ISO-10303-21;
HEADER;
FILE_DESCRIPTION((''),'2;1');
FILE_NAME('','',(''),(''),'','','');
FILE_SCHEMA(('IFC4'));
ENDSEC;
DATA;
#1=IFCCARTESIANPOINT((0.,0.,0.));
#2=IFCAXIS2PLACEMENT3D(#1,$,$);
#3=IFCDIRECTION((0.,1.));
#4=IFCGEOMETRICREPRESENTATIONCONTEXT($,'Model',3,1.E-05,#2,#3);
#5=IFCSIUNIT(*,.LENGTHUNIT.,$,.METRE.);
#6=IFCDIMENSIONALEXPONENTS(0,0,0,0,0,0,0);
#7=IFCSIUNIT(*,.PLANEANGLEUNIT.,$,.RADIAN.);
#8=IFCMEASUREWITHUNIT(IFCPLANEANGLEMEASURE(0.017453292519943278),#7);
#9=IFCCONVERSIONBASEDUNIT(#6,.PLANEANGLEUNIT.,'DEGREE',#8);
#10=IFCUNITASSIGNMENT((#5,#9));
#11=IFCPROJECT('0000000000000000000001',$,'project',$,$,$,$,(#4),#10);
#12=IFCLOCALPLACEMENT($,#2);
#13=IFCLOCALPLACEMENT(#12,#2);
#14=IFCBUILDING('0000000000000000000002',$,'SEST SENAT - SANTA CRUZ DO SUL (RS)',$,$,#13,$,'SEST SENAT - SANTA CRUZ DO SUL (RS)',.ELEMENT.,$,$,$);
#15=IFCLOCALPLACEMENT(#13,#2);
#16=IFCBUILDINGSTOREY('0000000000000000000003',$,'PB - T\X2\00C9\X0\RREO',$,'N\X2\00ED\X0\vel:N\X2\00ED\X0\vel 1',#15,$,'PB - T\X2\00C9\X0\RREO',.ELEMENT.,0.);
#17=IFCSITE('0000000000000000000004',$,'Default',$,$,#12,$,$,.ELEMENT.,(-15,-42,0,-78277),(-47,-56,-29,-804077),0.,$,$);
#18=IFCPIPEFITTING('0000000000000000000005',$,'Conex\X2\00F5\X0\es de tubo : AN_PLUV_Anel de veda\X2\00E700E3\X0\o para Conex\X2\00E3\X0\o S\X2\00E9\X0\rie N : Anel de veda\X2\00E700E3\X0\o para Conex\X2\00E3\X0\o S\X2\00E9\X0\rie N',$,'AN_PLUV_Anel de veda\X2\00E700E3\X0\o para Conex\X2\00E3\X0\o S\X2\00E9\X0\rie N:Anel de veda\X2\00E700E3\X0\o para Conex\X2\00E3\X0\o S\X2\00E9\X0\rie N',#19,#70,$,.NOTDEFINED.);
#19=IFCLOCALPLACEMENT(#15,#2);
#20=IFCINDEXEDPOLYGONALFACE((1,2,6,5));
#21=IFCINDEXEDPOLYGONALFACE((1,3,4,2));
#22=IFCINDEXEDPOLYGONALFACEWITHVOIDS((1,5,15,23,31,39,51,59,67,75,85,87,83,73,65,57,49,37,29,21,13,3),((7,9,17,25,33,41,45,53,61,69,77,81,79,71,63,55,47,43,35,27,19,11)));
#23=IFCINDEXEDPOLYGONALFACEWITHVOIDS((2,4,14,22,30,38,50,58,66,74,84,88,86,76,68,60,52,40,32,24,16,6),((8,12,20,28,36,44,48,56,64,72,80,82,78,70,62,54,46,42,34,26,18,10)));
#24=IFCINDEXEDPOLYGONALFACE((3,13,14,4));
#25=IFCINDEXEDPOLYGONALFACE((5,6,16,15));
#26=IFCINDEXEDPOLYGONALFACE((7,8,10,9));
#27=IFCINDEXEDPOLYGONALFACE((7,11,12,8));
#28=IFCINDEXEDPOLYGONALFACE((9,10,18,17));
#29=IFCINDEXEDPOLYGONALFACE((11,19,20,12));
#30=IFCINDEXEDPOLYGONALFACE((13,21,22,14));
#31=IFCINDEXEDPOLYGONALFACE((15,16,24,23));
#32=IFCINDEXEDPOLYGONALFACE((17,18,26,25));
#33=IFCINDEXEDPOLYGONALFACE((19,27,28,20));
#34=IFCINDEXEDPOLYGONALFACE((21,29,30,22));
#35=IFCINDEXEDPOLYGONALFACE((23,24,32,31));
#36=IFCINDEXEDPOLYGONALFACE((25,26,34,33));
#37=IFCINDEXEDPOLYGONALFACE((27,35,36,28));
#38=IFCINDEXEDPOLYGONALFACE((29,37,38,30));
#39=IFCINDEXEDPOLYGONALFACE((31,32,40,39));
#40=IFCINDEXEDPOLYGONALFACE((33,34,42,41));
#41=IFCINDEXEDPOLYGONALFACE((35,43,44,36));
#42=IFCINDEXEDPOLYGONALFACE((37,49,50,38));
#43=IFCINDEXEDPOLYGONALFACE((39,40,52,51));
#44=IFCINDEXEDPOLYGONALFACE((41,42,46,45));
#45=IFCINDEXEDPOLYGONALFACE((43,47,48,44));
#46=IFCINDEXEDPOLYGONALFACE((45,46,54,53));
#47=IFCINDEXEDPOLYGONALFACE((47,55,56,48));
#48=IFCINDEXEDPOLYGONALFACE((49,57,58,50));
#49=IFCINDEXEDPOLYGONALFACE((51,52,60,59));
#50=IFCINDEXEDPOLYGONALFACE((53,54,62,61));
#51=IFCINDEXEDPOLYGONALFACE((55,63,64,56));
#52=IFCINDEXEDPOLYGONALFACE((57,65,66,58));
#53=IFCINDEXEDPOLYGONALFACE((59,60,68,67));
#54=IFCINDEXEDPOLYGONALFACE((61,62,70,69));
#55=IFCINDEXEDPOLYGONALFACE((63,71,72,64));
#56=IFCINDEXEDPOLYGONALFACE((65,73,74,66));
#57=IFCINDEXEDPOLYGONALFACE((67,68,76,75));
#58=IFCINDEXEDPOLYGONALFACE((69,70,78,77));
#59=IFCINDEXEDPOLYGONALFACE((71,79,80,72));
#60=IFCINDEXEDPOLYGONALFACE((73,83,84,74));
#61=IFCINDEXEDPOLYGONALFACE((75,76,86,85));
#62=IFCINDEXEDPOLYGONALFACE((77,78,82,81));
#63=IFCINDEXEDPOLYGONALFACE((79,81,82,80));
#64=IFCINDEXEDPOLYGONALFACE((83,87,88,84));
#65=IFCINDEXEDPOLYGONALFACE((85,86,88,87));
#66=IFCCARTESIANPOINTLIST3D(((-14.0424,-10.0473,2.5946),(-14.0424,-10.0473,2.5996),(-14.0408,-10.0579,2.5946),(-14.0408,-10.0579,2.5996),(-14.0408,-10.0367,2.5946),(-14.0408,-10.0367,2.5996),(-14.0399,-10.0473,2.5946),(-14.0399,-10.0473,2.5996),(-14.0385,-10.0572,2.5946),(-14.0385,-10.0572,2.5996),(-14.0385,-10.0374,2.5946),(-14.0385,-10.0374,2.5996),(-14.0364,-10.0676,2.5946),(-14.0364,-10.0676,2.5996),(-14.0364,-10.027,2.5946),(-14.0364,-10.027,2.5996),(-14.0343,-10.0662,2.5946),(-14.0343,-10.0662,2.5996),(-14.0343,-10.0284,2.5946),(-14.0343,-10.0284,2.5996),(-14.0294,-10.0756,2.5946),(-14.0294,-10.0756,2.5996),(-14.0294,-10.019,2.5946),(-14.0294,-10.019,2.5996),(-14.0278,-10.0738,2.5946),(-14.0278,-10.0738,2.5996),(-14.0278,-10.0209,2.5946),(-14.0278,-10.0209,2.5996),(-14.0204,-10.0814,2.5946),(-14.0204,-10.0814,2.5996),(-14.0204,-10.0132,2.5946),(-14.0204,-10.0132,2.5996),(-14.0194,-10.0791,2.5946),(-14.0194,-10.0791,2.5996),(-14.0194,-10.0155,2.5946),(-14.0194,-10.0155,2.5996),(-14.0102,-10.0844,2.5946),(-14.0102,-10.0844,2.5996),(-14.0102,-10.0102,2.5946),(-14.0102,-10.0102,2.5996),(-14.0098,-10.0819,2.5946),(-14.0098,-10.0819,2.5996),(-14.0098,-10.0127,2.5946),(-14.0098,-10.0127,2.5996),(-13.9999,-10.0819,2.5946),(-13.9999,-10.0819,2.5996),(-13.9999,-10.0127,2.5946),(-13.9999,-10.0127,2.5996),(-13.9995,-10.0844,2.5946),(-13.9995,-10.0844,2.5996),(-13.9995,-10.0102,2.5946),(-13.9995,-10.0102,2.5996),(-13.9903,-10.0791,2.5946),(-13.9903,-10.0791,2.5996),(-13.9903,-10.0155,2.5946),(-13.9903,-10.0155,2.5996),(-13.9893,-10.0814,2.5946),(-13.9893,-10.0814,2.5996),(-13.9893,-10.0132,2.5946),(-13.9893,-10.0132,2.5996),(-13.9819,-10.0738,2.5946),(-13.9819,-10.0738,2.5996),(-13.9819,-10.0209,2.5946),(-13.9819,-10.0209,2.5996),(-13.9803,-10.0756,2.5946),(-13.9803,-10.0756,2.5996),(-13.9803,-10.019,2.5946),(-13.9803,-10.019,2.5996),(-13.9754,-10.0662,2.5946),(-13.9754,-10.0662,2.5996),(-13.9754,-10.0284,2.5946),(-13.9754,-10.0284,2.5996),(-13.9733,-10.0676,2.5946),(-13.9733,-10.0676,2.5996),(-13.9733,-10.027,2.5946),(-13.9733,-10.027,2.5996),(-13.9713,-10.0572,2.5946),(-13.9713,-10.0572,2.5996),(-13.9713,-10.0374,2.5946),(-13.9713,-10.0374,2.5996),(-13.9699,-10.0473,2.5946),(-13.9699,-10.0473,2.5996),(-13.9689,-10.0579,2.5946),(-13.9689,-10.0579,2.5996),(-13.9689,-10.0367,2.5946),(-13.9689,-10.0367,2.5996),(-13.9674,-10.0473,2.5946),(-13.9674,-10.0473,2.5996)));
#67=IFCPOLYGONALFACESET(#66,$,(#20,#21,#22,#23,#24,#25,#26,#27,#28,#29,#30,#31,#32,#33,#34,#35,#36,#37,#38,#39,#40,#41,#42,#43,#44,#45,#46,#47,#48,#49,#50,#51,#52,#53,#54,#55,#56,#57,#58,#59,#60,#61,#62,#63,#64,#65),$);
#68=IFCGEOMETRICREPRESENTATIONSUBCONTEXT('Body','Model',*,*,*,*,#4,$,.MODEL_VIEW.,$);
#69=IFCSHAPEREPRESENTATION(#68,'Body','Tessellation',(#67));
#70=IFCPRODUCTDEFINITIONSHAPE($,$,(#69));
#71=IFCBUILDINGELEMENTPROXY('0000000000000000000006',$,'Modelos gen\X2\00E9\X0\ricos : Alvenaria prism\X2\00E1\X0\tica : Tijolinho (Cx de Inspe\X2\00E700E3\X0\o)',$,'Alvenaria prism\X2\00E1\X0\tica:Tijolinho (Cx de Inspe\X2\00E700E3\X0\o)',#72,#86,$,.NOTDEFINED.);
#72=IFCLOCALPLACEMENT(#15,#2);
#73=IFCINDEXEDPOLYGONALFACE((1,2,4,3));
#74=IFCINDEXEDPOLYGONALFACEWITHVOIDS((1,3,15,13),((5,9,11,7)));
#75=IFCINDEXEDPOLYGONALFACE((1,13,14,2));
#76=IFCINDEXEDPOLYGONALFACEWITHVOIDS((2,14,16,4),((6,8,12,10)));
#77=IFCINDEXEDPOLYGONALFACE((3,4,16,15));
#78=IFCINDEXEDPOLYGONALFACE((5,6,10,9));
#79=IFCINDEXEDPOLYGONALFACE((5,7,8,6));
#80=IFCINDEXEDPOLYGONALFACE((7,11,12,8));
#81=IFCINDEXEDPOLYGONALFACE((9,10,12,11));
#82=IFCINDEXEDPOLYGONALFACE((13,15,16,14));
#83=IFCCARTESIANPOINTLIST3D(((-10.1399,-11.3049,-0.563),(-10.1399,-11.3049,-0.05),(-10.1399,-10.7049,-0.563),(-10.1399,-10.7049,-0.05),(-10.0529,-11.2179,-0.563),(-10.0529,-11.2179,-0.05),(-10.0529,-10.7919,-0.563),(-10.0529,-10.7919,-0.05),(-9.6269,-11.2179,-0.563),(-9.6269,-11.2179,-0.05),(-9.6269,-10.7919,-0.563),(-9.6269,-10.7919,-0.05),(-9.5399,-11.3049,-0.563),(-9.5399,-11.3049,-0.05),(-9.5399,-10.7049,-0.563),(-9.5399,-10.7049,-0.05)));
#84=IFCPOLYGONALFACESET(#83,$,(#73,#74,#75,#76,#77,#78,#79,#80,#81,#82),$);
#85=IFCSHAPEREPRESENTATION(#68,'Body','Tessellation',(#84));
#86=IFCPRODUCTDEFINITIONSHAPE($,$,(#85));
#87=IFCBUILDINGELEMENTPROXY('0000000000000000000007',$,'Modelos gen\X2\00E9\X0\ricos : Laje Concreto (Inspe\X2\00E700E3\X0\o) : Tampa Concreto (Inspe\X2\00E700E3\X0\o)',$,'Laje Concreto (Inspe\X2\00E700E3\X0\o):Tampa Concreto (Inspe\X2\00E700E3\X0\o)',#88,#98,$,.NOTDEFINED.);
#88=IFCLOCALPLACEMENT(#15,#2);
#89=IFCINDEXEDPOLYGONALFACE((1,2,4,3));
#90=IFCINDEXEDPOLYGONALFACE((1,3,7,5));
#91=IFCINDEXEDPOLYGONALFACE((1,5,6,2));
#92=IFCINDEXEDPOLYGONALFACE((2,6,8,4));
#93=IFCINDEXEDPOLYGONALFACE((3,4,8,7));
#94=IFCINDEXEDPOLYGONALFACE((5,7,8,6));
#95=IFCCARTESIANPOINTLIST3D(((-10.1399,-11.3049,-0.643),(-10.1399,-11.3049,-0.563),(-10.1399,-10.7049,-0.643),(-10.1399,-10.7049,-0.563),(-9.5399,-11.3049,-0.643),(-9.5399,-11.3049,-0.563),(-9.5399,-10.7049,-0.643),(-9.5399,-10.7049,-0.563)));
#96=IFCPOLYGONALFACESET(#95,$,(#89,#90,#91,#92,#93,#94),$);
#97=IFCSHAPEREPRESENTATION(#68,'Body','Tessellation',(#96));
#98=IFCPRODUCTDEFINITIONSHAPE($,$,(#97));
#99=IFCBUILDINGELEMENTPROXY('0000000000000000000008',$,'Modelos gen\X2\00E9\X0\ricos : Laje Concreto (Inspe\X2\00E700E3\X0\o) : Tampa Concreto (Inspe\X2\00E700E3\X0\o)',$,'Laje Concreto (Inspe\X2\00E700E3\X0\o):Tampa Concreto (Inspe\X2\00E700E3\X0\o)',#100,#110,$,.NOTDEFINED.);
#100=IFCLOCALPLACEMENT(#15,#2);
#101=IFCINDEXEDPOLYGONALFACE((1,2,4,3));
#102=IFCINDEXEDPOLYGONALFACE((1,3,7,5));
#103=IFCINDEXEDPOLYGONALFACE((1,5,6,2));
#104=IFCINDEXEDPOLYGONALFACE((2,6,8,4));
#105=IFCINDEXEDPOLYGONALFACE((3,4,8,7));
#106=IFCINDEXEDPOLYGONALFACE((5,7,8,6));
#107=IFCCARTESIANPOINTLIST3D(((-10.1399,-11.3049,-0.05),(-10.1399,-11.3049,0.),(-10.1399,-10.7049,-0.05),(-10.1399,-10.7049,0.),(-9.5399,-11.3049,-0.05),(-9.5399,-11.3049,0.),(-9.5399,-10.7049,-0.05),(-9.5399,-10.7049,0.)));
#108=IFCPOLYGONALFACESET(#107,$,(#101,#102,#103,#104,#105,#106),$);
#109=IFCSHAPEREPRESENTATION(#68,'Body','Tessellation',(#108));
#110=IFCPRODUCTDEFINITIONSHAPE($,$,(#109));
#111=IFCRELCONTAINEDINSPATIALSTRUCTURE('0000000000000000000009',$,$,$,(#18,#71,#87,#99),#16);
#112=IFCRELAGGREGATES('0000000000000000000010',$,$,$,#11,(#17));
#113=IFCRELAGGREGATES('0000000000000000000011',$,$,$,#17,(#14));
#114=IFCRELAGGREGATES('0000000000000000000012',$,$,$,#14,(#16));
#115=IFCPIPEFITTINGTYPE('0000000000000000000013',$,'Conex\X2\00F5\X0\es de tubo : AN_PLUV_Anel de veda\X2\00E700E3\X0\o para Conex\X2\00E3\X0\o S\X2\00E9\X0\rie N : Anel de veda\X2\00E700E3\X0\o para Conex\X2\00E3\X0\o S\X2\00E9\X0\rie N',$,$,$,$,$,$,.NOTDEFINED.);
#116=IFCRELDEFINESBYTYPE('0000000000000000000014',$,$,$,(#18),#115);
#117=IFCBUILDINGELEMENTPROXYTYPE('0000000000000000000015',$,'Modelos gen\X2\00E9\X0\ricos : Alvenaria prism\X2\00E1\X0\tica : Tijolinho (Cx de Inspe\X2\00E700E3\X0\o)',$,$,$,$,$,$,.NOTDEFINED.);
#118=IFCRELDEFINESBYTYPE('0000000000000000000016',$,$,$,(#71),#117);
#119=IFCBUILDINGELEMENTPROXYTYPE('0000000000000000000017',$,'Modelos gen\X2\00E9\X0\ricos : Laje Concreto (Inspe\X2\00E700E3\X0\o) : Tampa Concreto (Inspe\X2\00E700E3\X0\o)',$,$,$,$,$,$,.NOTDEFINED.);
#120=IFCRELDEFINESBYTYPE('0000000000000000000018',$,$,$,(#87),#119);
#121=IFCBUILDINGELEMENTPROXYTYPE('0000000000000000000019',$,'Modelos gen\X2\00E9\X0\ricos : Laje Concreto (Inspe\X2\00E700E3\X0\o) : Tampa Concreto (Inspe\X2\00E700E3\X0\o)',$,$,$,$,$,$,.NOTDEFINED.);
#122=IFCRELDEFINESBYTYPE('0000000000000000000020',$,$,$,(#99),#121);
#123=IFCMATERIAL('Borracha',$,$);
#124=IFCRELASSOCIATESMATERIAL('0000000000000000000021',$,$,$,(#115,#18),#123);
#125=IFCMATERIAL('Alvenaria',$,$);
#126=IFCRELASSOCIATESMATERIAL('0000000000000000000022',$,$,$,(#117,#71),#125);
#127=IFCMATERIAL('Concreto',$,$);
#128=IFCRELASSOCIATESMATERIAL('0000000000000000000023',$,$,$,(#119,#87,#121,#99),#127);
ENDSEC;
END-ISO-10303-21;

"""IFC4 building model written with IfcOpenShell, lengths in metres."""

from ifc_helpers import new_model, entity, si_unit, converted_unit, direction, frame, origin, place, context, subcontext, project, spatial, arc, indexed_curve, outline, extrude, source, transform, mapped, material, type_object, type_shapes, element, save


model = new_model("IFC4")

# Units and contexts
model_context = context("Model", 3, precision=1e-05, world=origin(), true_north=direction((0.0, 1.0)))
body_context = subcontext(model_context, "Body", "Model", "MODEL_VIEW")
ifc_project = project(units=[si_unit("LENGTHUNIT", "METRE"), converted_unit("PLANEANGLEUNIT", "DEGREE", entity("IfcPlaneAngleMeasure", 0.017453292519943278), si_unit("PLANEANGLEUNIT", "RADIAN"), dimensions=[0, 0, 0, 0, 0, 0, 0])], contexts=[model_context])

# Site, building, storey
site_placement = place(None, origin())
site = spatial("IfcSite", under=ifc_project, at=site_placement, Name="Default", CompositionType="ELEMENT", RefLatitude=(-15, -42, 0, -78277), RefLongitude=(-47, -56, -29, -804077), RefElevation=0.0)
building_placement = place(site_placement, origin())
building = spatial("IfcBuilding", under=site, at=building_placement, Name="SEST SENAT - SANTA CRUZ DO SUL (RS)", LongName="SEST SENAT - SANTA CRUZ DO SUL (RS)", CompositionType="ELEMENT")
storey_placement = place(building_placement, origin())
storey = spatial("IfcBuildingStorey", under=building, at=storey_placement, Name="PB - TÉRREO", ObjectType="Nível:Nível 1", LongName="PB - TÉRREO", CompositionType="ELEMENT", Elevation=0.0)

# Pipe fitting
ifc_material_1 = material(Name="Borracha")
pipe_fitting_type = type_object("IfcPipeFittingType", Name="Conexões de tubo : AN_PLUV_Anel de vedação para Conexão Série N : Anel de vedação para Conexão Série N", PredefinedType="NOTDEFINED", material=ifc_material_1)
shared_shape_1 = source(origin(), body_context, "Body", "SweptSolid", [
    extrude(outline(indexed_curve([(-0.0375, 0.0), (0.0, -0.0375), (0.0375, 0.0), (0.0, 0.0375)], segments=[arc(1, 2, 3), arc(3, 4, 1)], self_intersect=False), holes=[indexed_curve([(-0.035, 0.0), (0.0, 0.035), (0.035, 0.0), (0.0, -0.035)], segments=[arc(1, 2, 3), arc(3, 4, 1)], self_intersect=False)]), frame((0.0, 0.0, -0.005)), (0.0, 0.0, 1.0), 0.005),
])
type_shapes(pipe_fitting_type, [shared_shape_1])
for number, where, z_axis, x_axis, name in (
    (1, (-14.0049, -10.0473, 2.5946), (0.0, 0.0, -1.0), (-1.0, 0.0, 0.0), "Conexões de tubo : AN_PLUV_Anel de vedação para Conexão Série N : Anel de vedação para Conexão Série N"),
):
    element("IfcPipeFitting", number, at=place(storey_placement, frame(where, z_axis=z_axis, x_axis=x_axis)), inside=storey, type_object=pipe_fitting_type, material=ifc_material_1, Name=name, ObjectType="AN_PLUV_Anel de vedação para Conexão Série N:Anel de vedação para Conexão Série N", PredefinedType="NOTDEFINED", context=body_context, shape_type="MappedRepresentation", body=[
        mapped(shared_shape_1, transform((0.0, 0.0, 0.0), scale=1.0)),
    ])

# Building element proxies
ifc_material_2 = material(Name="Alvenaria")
building_element_proxy_type_1 = type_object("IfcBuildingElementProxyType", Name="Modelos genéricos : Alvenaria prismática : Tijolinho (Cx de Inspeção)", PredefinedType="NOTDEFINED", material=ifc_material_2)
shared_shape_2 = source(origin(), body_context, "Body", "SweptSolid", [
    extrude(outline(indexed_curve([(-0.3, -0.3), (0.3, -0.3), (0.3, 0.3), (-0.3, 0.3), (-0.3, -0.3)], self_intersect=False), holes=[indexed_curve([(0.213, 0.213), (0.213, -0.213), (-0.213, -0.213), (-0.213, 0.213), (0.213, 0.213)], self_intersect=False)]), frame((0.3, 0.0, -0.013), z_axis=(0.0, 0.0, 1.0), x_axis=(-1.0, 0.0, 0.0)), (0.0, 0.0, 1.0), 0.513),
])
type_shapes(building_element_proxy_type_1, [shared_shape_2])
proxy_1_placement = place(storey_placement, frame((-9.5399, -11.0049, -0.55), z_axis=(0.0, 0.0, 1.0), x_axis=(-1.0, 0.0, 0.0)))
element("IfcBuildingElementProxy", 2, at=proxy_1_placement, inside=storey, type_object=building_element_proxy_type_1, material=ifc_material_2, Name="Modelos genéricos : Alvenaria prismática : Tijolinho (Cx de Inspeção)", ObjectType="Alvenaria prismática:Tijolinho (Cx de Inspeção)", PredefinedType="NOTDEFINED", context=body_context, shape_type="MappedRepresentation", body=[
    mapped(shared_shape_2, transform((0.0, 0.0, 0.0), scale=1.0)),
])
ifc_material_3 = material(Name="Concreto")
building_element_proxy_type_2 = type_object("IfcBuildingElementProxyType", Name="Modelos genéricos : Laje Concreto (Inspeção) : Tampa Concreto (Inspeção)", PredefinedType="NOTDEFINED", material=ifc_material_3)
shared_shape_3 = source(origin(), body_context, "Body", "SweptSolid", [
    extrude(outline(indexed_curve([(-0.3, -0.3), (0.3, -0.3), (0.3, 0.3), (-0.3, 0.3), (-0.3, -0.3)], self_intersect=False)), frame((0.3, 0.0, -0.08), z_axis=(0.0, 0.0, 1.0), x_axis=(-1.0, 0.0, 0.0)), (0.0, 0.0, 1.0), 0.08),
])
type_shapes(building_element_proxy_type_2, [shared_shape_3])
proxy_2_placement = place(storey_placement, frame((-9.5399, -11.0049, -0.563), z_axis=(0.0, 0.0, 1.0), x_axis=(-1.0, 0.0, 0.0)))
element("IfcBuildingElementProxy", 3, at=proxy_2_placement, inside=storey, type_object=building_element_proxy_type_2, material=ifc_material_3, Name="Modelos genéricos : Laje Concreto (Inspeção) : Tampa Concreto (Inspeção)", ObjectType="Laje Concreto (Inspeção):Tampa Concreto (Inspeção)", PredefinedType="NOTDEFINED", context=body_context, shape_type="MappedRepresentation", body=[
    mapped(shared_shape_3, transform((0.0, 0.0, 0.0), scale=1.0)),
])
building_element_proxy_type_3 = type_object("IfcBuildingElementProxyType", Name="Modelos genéricos : Laje Concreto (Inspeção) : Tampa Concreto (Inspeção)", PredefinedType="NOTDEFINED", material=ifc_material_3)
shared_shape_4 = source(origin(), body_context, "Body", "SweptSolid", [
    extrude(outline(indexed_curve([(-0.3, -0.3), (0.3, -0.3), (0.3, 0.3), (-0.3, 0.3), (-0.3, -0.3)], self_intersect=False)), frame((0.3, 0.0, -0.05), z_axis=(0.0, 0.0, 1.0), x_axis=(-1.0, 0.0, 0.0)), (0.0, 0.0, 1.0), 0.05),
])
type_shapes(building_element_proxy_type_3, [shared_shape_4])
proxy_3_placement = place(storey_placement, frame((-9.5399, -11.0049, 0.0), z_axis=(0.0, 0.0, 1.0), x_axis=(-1.0, 0.0, 0.0)))
element("IfcBuildingElementProxy", 4, at=proxy_3_placement, inside=storey, type_object=building_element_proxy_type_3, material=ifc_material_3, Name="Modelos genéricos : Laje Concreto (Inspeção) : Tampa Concreto (Inspeção)", ObjectType="Laje Concreto (Inspeção):Tampa Concreto (Inspeção)", PredefinedType="NOTDEFINED", context=body_context, shape_type="MappedRepresentation", body=[
    mapped(shared_shape_4, transform((0.0, 0.0, 0.0), scale=1.0)),
])

save(model, "model.ifc")
